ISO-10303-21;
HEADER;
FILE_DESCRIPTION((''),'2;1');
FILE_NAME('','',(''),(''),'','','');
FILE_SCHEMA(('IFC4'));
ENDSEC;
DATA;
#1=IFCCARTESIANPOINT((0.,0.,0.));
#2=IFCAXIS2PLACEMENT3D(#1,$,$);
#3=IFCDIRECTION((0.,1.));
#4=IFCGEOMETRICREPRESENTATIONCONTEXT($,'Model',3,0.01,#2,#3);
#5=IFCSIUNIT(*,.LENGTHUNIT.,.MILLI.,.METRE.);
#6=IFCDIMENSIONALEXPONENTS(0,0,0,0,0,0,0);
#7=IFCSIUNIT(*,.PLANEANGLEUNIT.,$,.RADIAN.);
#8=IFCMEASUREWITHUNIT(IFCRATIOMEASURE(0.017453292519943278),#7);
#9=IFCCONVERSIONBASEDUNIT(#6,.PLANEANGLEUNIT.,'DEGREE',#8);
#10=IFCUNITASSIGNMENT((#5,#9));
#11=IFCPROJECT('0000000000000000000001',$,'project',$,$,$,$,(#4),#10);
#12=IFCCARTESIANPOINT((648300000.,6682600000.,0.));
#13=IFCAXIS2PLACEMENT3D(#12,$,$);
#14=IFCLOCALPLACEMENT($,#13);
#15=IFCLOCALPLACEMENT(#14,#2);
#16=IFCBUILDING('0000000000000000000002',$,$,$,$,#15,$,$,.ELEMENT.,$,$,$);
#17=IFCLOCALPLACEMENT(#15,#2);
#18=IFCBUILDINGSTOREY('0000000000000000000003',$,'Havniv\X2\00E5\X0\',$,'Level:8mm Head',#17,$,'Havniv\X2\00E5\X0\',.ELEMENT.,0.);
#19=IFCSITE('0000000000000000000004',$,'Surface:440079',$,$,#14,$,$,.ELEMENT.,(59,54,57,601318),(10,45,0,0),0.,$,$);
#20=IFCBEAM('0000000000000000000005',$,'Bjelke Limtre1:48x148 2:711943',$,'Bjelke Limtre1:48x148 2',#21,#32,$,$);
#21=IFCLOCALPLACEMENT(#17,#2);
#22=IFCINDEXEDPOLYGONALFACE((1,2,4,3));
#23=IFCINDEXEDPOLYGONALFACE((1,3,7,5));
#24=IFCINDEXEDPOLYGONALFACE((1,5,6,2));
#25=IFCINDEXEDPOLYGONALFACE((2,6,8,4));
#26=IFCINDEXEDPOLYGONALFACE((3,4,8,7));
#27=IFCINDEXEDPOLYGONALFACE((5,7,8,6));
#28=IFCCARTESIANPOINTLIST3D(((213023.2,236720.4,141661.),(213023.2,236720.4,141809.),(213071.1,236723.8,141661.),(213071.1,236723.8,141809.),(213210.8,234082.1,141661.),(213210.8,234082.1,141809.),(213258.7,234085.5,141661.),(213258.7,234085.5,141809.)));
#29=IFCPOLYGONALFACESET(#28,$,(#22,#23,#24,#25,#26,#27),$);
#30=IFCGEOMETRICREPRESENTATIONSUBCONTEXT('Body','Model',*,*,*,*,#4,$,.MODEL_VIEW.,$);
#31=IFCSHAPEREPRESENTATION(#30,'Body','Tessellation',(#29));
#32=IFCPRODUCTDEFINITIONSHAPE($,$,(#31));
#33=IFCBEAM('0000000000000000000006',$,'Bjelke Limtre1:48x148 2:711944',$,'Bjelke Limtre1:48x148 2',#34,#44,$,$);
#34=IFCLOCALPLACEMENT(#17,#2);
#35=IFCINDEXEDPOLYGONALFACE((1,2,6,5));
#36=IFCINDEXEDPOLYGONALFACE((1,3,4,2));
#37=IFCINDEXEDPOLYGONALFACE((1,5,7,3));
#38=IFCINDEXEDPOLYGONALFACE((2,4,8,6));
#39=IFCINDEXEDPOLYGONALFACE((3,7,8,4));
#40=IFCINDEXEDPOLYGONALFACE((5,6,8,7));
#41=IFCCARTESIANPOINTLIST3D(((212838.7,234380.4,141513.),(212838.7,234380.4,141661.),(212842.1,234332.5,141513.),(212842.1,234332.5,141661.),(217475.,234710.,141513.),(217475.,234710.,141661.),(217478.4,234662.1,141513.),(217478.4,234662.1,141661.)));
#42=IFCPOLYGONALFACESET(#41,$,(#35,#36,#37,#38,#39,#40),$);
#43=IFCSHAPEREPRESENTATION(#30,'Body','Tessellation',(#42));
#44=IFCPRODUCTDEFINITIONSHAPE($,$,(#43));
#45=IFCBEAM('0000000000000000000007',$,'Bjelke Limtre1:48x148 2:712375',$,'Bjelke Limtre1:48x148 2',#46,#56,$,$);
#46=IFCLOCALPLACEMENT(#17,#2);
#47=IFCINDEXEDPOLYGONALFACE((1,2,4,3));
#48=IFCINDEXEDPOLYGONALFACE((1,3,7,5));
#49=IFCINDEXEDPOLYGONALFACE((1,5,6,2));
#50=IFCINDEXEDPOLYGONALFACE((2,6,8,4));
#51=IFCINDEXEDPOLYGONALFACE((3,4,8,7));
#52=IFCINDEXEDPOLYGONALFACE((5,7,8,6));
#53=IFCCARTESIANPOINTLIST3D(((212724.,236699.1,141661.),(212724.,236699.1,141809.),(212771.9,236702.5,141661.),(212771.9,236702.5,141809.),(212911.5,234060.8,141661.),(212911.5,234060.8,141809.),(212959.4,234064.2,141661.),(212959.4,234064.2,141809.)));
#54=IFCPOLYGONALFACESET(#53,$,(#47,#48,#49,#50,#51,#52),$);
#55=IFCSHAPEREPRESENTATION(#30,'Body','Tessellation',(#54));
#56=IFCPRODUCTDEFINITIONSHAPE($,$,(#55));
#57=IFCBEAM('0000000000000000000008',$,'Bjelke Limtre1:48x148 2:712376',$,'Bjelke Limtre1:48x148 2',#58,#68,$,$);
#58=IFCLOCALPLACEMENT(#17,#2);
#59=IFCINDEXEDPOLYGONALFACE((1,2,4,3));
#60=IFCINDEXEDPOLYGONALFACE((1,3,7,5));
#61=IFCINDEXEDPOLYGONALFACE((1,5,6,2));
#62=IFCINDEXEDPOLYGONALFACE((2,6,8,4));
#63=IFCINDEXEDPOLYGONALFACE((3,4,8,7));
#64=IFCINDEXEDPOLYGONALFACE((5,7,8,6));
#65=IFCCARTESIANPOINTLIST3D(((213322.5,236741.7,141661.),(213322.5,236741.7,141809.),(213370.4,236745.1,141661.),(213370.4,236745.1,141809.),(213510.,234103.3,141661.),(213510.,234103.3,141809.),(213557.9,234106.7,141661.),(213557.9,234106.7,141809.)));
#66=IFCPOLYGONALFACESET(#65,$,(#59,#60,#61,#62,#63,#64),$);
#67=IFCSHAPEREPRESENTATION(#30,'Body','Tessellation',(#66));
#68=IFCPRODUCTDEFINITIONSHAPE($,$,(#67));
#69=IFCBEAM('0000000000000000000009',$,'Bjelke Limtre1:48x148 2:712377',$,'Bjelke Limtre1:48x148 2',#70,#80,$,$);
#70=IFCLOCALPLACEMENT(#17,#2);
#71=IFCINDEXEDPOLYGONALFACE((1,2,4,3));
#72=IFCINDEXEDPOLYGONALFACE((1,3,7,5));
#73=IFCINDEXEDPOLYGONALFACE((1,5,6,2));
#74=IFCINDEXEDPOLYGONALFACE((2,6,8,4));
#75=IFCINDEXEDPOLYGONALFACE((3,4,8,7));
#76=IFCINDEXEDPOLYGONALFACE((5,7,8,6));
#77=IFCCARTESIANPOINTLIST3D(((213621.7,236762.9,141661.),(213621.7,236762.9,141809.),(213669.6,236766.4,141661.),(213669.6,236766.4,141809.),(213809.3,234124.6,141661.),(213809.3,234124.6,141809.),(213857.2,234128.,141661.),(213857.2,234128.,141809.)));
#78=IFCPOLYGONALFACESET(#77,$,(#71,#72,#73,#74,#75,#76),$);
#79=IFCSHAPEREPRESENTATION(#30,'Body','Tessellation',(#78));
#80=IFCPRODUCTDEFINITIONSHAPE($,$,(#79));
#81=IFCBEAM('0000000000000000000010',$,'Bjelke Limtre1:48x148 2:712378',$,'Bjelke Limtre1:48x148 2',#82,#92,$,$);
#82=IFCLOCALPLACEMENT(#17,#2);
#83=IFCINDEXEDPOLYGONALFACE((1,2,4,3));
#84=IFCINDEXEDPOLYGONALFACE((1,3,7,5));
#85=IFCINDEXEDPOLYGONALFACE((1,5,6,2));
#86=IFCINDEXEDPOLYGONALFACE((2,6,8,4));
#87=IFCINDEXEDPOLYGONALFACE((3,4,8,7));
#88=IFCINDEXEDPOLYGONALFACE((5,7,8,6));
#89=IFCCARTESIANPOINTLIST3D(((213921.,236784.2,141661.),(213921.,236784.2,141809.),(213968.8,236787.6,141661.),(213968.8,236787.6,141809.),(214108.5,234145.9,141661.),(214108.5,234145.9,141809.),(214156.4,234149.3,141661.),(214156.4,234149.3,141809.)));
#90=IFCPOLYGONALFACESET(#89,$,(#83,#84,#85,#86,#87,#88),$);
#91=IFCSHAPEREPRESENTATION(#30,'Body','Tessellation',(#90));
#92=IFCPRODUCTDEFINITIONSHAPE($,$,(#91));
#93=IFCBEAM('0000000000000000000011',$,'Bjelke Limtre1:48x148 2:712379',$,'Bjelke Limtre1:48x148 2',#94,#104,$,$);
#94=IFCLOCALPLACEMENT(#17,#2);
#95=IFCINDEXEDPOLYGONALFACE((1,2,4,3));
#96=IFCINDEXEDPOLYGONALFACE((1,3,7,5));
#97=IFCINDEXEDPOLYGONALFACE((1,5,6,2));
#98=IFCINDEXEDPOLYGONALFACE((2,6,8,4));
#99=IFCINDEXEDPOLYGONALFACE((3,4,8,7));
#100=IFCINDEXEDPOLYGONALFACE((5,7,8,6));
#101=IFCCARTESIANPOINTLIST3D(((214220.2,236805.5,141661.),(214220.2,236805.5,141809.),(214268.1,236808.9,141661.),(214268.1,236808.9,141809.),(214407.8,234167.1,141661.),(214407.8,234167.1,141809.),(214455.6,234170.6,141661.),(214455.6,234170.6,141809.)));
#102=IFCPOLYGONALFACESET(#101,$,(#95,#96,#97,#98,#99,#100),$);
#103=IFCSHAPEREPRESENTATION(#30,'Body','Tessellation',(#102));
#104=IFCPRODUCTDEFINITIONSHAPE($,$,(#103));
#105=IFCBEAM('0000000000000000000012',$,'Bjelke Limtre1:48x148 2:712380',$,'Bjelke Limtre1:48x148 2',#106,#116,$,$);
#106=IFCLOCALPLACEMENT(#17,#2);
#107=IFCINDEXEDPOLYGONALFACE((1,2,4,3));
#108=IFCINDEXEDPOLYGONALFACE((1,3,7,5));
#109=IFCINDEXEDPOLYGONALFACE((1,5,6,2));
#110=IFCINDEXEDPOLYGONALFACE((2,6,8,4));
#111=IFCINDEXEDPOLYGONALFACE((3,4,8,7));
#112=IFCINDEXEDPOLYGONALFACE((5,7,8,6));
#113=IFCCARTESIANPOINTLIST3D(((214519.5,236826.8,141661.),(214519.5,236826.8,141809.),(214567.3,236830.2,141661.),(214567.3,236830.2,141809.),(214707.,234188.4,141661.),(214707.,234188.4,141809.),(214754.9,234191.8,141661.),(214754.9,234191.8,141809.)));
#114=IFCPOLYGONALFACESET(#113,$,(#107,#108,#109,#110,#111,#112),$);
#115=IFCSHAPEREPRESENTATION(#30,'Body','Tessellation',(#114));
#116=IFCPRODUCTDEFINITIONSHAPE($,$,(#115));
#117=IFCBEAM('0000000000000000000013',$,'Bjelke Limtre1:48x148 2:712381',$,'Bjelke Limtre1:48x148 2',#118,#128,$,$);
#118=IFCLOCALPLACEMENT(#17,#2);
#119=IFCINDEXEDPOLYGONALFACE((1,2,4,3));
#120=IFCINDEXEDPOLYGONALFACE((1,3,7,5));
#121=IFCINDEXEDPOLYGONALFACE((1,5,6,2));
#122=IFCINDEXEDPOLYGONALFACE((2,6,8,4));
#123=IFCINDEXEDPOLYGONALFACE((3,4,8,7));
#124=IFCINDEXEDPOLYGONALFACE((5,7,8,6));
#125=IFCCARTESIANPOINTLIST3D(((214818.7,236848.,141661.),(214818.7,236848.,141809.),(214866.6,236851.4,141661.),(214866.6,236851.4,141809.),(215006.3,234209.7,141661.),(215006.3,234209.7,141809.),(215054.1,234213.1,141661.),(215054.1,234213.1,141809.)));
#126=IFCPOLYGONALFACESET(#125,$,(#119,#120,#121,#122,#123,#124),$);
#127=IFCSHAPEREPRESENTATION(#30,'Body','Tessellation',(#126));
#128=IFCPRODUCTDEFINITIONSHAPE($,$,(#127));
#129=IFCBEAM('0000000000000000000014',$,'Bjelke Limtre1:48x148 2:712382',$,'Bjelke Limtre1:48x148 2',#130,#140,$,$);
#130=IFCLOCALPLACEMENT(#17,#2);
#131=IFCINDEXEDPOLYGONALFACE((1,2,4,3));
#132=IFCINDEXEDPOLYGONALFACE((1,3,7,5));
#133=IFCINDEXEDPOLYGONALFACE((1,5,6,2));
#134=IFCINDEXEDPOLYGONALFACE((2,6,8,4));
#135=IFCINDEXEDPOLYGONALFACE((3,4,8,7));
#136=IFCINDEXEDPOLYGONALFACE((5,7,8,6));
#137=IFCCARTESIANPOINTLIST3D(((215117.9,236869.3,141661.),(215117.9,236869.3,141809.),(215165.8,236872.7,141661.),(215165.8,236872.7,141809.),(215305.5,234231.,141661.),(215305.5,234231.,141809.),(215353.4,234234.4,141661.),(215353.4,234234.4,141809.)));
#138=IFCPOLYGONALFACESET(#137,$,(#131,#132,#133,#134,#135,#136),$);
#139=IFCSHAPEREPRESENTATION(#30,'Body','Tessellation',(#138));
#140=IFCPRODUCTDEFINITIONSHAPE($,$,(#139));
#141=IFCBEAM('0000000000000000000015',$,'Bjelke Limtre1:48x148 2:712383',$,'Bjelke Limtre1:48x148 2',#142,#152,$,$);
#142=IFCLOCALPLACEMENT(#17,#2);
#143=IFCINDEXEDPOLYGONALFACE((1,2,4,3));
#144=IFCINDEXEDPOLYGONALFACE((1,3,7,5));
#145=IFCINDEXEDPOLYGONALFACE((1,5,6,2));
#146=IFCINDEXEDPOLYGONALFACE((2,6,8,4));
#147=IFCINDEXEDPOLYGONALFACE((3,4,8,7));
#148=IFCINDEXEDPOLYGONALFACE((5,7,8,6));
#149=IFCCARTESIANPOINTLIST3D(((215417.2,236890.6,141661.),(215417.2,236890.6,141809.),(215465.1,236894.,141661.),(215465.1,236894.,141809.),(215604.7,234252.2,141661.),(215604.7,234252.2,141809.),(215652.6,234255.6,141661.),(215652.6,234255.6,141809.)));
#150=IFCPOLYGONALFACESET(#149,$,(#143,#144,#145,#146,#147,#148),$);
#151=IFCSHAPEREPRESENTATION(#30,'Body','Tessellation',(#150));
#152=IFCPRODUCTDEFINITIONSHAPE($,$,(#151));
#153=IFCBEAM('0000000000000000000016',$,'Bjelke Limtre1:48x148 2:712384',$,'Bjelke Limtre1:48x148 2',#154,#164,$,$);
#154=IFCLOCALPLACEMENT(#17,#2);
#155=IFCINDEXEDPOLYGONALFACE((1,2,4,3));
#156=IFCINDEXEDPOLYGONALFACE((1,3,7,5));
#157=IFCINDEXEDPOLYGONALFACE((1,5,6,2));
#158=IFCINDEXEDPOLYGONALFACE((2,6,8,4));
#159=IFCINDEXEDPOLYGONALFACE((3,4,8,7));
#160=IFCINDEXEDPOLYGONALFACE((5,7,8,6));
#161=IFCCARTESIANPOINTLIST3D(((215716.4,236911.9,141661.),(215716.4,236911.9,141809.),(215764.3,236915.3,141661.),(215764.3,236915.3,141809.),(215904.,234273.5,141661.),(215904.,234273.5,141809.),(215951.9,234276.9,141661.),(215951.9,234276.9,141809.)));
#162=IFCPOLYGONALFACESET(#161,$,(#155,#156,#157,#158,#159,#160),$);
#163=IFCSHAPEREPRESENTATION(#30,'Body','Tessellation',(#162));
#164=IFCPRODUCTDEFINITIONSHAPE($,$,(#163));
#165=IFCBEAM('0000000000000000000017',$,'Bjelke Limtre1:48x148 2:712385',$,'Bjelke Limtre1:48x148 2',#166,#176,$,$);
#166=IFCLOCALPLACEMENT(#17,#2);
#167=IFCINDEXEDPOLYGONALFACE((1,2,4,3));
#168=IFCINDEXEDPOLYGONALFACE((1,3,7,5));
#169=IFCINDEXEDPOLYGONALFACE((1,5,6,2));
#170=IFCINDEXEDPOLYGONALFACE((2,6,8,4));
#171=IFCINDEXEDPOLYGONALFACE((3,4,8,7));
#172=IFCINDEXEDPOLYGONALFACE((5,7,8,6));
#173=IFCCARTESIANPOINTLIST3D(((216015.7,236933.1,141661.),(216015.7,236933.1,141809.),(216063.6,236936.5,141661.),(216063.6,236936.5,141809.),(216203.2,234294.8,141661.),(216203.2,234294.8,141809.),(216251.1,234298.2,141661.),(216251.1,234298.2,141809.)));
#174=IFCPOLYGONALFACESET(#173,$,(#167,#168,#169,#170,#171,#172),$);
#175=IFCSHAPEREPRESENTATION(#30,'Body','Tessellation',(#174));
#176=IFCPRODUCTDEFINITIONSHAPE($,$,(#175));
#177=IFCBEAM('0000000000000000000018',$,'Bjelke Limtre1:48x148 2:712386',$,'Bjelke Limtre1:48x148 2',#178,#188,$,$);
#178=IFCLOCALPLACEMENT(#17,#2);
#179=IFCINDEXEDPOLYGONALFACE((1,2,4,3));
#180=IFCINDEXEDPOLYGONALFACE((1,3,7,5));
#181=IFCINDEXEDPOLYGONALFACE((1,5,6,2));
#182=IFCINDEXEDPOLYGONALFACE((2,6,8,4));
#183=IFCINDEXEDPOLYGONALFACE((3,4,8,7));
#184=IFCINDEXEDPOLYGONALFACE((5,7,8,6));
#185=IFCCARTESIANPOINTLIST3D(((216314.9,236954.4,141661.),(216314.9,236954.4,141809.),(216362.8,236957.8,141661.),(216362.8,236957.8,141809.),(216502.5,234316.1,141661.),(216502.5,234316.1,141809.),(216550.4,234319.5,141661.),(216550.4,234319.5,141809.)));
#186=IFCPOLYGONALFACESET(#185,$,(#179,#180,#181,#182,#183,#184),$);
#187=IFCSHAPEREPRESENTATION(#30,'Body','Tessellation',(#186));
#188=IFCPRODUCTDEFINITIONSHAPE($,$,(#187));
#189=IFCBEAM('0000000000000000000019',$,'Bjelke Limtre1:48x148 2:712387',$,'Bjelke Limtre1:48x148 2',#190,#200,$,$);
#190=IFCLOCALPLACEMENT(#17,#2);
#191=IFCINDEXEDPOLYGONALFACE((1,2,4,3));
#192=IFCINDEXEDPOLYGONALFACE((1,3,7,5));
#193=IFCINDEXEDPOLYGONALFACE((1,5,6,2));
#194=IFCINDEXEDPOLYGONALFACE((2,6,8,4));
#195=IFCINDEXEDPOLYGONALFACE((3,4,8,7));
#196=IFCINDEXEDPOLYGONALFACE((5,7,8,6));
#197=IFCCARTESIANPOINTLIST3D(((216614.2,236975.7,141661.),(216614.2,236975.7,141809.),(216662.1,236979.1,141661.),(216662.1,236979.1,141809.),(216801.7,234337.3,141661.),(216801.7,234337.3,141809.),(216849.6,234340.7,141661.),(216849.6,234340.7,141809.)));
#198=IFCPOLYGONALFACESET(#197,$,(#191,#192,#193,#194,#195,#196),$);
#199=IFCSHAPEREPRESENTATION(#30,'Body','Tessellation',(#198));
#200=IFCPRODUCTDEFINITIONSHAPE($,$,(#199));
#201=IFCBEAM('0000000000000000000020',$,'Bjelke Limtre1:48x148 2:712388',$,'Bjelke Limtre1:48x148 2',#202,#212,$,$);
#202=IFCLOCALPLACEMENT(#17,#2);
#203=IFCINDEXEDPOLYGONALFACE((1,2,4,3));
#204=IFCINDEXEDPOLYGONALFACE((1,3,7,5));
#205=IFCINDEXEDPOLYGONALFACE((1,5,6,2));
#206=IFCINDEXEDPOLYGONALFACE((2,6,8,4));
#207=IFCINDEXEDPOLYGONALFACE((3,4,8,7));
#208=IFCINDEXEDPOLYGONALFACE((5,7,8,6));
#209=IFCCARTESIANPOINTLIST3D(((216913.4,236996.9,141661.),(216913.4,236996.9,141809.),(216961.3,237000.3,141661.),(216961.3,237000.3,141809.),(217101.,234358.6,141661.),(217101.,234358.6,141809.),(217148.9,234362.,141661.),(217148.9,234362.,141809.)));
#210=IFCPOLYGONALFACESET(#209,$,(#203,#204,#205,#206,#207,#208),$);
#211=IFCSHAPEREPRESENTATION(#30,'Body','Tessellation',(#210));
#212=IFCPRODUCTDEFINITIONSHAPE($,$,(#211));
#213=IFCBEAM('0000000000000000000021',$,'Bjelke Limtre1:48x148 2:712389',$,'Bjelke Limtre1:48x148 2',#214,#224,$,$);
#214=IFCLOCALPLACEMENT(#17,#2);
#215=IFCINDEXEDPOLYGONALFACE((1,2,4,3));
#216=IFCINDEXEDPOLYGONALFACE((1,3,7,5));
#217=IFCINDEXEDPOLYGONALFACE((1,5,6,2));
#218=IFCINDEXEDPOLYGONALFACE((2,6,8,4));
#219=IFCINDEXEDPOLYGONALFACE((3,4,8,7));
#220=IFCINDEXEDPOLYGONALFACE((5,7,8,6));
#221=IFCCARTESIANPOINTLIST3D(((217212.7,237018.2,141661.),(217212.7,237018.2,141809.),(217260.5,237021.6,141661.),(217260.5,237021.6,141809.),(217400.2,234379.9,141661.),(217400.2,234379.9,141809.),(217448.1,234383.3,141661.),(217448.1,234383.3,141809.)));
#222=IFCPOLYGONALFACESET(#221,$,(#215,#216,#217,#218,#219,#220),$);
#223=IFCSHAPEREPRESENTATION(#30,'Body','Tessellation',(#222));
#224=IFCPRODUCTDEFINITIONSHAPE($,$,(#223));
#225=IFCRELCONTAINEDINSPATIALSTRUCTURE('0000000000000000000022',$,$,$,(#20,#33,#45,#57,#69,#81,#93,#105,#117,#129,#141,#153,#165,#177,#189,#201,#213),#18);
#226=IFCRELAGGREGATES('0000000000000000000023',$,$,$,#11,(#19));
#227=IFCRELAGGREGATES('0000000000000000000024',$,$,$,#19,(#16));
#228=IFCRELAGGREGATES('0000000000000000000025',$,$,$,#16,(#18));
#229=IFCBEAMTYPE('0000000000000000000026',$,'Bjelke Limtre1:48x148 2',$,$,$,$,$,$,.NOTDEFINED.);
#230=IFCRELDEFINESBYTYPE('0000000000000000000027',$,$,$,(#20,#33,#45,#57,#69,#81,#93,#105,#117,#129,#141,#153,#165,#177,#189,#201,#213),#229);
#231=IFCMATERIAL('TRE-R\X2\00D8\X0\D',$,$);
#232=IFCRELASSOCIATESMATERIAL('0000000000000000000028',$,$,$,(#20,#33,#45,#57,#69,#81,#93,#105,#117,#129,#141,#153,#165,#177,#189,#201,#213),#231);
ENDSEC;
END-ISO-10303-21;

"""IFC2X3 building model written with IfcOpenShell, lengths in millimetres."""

from ifc_helpers import new_model, entity, si_unit, converted_unit, direction, frame, frame_2d, origin, origin_2d_with_axis, place, context, subcontext, project, spatial, rectangle, extrude, material, type_object, element, save


model = new_model("IFC2X3")

# Units and contexts
model_context = context("Model", 3, precision=0.01, world=origin(), true_north=direction((0.0, 1.0)))
body_context = subcontext(model_context, "Body", "Model", "MODEL_VIEW")
ifc_project = project(units=[si_unit("LENGTHUNIT", "METRE", prefix="MILLI"), converted_unit("PLANEANGLEUNIT", "DEGREE", entity("IfcRatioMeasure", 0.017453292519943278), si_unit("PLANEANGLEUNIT", "RADIAN"), dimensions=[0, 0, 0, 0, 0, 0, 0])], contexts=[model_context])

# Site, building, storey
site_placement = place(None, frame((648300000.0, 6682600000.0, 0.0)))
site = spatial("IfcSite", under=ifc_project, at=site_placement, Name="Surface:440079", CompositionType="ELEMENT", RefLatitude=(59, 54, 57, 601318), RefLongitude=(10, 45, 0, 0), RefElevation=0.0)
building_placement = place(site_placement, origin())
building = spatial("IfcBuilding", under=site, at=building_placement, CompositionType="ELEMENT")
storey_placement = place(building_placement, origin())
storey = spatial("IfcBuildingStorey", under=building, at=storey_placement, Name="Havnivå", ObjectType="Level:8mm Head", LongName="Havnivå", CompositionType="ELEMENT", Elevation=0.0)

# Beams
ifc_material_1 = material(Name="TRE-RØD")
beam_type = type_object("IfcBeamType", Name="Bjelke Limtre1:48x148 2", PredefinedType="NOTDEFINED")
beam_1_placement = place(storey_placement, frame((213047.2, 236722.1, 141809.0), z_axis=(0.0, 0.0, 1.0), x_axis=(0.070908, -0.997483, 0.0)))
element("IfcBeam", 1, at=beam_1_placement, inside=storey, type_object=beam_type, material=ifc_material_1, Name="Bjelke Limtre1:48x148 2:711943", ObjectType="Bjelke Limtre1:48x148 2", context=body_context, shape_type="SweptSolid", body=[
    extrude(rectangle(XDim=148.0, YDim=48.0, at=origin_2d_with_axis()), frame((0.0, 0.0, -74.0), z_axis=(1.0, 0.0, 0.0), x_axis=(0.0, 0.0, -1.0)), (0.0, 0.0, 1.0), 2645.0),
])
beam_2_placement = place(storey_placement, frame((212840.4, 234356.5, 141661.0), z_axis=(0.0, 0.0, 1.0), x_axis=(0.997483, 0.070908, 0.0)))
element("IfcBeam", 2, at=beam_2_placement, inside=storey, type_object=beam_type, material=ifc_material_1, Name="Bjelke Limtre1:48x148 2:711944", ObjectType="Bjelke Limtre1:48x148 2", context=body_context, shape_type="SweptSolid", body=[
    extrude(rectangle(XDim=148.0, YDim=48.0, at=frame_2d((0.0, 0.0), x_axis=(1.0, 0.0))), frame((0.0, 0.0, -74.0), z_axis=(1.0, 0.0, 0.0), x_axis=(0.0, 0.0, -1.0)), (0.0, 0.0, 1.0), 4648.0),
])
for number, where, z_axis, x_axis, name in (
    (3, (212747.9, 236700.8, 141809.0), (0.0, 0.0, 1.0), (0.070908, -0.997483, 0.0), "Bjelke Limtre1:48x148 2:712375"),
    (4, (213346.4, 236743.4, 141809.0), (0.0, 0.0, 1.0), (0.070908, -0.997483, 0.0), "Bjelke Limtre1:48x148 2:712376"),
    (5, (213645.7, 236764.6, 141809.0), (0.0, 0.0, 1.0), (0.070908, -0.997483, 0.0), "Bjelke Limtre1:48x148 2:712377"),
    (6, (213944.9, 236785.9, 141809.0), (0.0, 0.0, 1.0), (0.070908, -0.997483, 0.0), "Bjelke Limtre1:48x148 2:712378"),
):
    element("IfcBeam", number, at=place(storey_placement, frame(where, z_axis=z_axis, x_axis=x_axis)), inside=storey, type_object=beam_type, material=ifc_material_1, Name=name, ObjectType="Bjelke Limtre1:48x148 2", context=body_context, shape_type="SweptSolid", body=[
        extrude(rectangle(XDim=148.0, YDim=48.0, at=origin_2d_with_axis()), frame((0.0, 0.0, -74.0), z_axis=(1.0, 0.0, 0.0), x_axis=(0.0, 0.0, -1.0)), (0.0, 0.0, 1.0), 2645.0),
    ])
for number, where, z_axis, x_axis, name in (
    (7, (214244.2, 236807.2, 141809.0), (0.0, 0.0, 1.0), (0.070908, -0.997483, 0.0), "Bjelke Limtre1:48x148 2:712379"),
    (8, (214543.4, 236828.5, 141809.0), (0.0, 0.0, 1.0), (0.070908, -0.997483, 0.0), "Bjelke Limtre1:48x148 2:712380"),
):
    element("IfcBeam", number, at=place(storey_placement, frame(where, z_axis=z_axis, x_axis=x_axis)), inside=storey, type_object=beam_type, material=ifc_material_1, Name=name, ObjectType="Bjelke Limtre1:48x148 2", context=body_context, shape_type="SweptSolid", body=[
        extrude(rectangle(XDim=148.0, YDim=48.0, at=frame_2d((0.0, 0.0), x_axis=(1.0, 0.0))), frame((0.0, 0.0, -74.0), z_axis=(1.0, 0.0, 0.0), x_axis=(0.0, 0.0, -1.0)), (0.0, 0.0, 1.0), 2645.0),
    ])
for number, where, z_axis, x_axis, name in (
    (9, (214842.6, 236849.7, 141809.0), (0.0, 0.0, 1.0), (0.070908, -0.997483, 0.0), "Bjelke Limtre1:48x148 2:712381"),
    (10, (215141.9, 236871.0, 141809.0), (0.0, 0.0, 1.0), (0.070908, -0.997483, 0.0), "Bjelke Limtre1:48x148 2:712382"),
    (11, (215441.1, 236892.3, 141809.0), (0.0, 0.0, 1.0), (0.070908, -0.997483, 0.0), "Bjelke Limtre1:48x148 2:712383"),
    (12, (215740.4, 236913.6, 141809.0), (0.0, 0.0, 1.0), (0.070908, -0.997483, 0.0), "Bjelke Limtre1:48x148 2:712384"),
    (13, (216039.6, 236934.8, 141809.0), (0.0, 0.0, 1.0), (0.070908, -0.997483, 0.0), "Bjelke Limtre1:48x148 2:712385"),
    (14, (216338.9, 236956.1, 141809.0), (0.0, 0.0, 1.0), (0.070908, -0.997483, 0.0), "Bjelke Limtre1:48x148 2:712386"),
):
    element("IfcBeam", number, at=place(storey_placement, frame(where, z_axis=z_axis, x_axis=x_axis)), inside=storey, type_object=beam_type, material=ifc_material_1, Name=name, ObjectType="Bjelke Limtre1:48x148 2", context=body_context, shape_type="SweptSolid", body=[
        extrude(rectangle(XDim=148.0, YDim=48.0, at=origin_2d_with_axis()), frame((0.0, 0.0, -74.0), z_axis=(1.0, 0.0, 0.0), x_axis=(0.0, 0.0, -1.0)), (0.0, 0.0, 1.0), 2645.0),
    ])
for number, where, z_axis, x_axis, name in (
    (15, (216638.1, 236977.4, 141809.0), (0.0, 0.0, 1.0), (0.070908, -0.997483, 0.0), "Bjelke Limtre1:48x148 2:712387"),
    (16, (216937.4, 236998.6, 141809.0), (0.0, 0.0, 1.0), (0.070908, -0.997483, 0.0), "Bjelke Limtre1:48x148 2:712388"),
    (17, (217236.6, 237019.9, 141809.0), (0.0, 0.0, 1.0), (0.070908, -0.997483, 0.0), "Bjelke Limtre1:48x148 2:712389"),
):
    element("IfcBeam", number, at=place(storey_placement, frame(where, z_axis=z_axis, x_axis=x_axis)), inside=storey, type_object=beam_type, material=ifc_material_1, Name=name, ObjectType="Bjelke Limtre1:48x148 2", context=body_context, shape_type="SweptSolid", body=[
        extrude(rectangle(XDim=148.0, YDim=48.0, at=frame_2d((0.0, 0.0), x_axis=(1.0, 0.0))), frame((0.0, 0.0, -74.0), z_axis=(1.0, 0.0, 0.0), x_axis=(0.0, 0.0, -1.0)), (0.0, 0.0, 1.0), 2645.0),
    ])

save(model, "model.ifc")
